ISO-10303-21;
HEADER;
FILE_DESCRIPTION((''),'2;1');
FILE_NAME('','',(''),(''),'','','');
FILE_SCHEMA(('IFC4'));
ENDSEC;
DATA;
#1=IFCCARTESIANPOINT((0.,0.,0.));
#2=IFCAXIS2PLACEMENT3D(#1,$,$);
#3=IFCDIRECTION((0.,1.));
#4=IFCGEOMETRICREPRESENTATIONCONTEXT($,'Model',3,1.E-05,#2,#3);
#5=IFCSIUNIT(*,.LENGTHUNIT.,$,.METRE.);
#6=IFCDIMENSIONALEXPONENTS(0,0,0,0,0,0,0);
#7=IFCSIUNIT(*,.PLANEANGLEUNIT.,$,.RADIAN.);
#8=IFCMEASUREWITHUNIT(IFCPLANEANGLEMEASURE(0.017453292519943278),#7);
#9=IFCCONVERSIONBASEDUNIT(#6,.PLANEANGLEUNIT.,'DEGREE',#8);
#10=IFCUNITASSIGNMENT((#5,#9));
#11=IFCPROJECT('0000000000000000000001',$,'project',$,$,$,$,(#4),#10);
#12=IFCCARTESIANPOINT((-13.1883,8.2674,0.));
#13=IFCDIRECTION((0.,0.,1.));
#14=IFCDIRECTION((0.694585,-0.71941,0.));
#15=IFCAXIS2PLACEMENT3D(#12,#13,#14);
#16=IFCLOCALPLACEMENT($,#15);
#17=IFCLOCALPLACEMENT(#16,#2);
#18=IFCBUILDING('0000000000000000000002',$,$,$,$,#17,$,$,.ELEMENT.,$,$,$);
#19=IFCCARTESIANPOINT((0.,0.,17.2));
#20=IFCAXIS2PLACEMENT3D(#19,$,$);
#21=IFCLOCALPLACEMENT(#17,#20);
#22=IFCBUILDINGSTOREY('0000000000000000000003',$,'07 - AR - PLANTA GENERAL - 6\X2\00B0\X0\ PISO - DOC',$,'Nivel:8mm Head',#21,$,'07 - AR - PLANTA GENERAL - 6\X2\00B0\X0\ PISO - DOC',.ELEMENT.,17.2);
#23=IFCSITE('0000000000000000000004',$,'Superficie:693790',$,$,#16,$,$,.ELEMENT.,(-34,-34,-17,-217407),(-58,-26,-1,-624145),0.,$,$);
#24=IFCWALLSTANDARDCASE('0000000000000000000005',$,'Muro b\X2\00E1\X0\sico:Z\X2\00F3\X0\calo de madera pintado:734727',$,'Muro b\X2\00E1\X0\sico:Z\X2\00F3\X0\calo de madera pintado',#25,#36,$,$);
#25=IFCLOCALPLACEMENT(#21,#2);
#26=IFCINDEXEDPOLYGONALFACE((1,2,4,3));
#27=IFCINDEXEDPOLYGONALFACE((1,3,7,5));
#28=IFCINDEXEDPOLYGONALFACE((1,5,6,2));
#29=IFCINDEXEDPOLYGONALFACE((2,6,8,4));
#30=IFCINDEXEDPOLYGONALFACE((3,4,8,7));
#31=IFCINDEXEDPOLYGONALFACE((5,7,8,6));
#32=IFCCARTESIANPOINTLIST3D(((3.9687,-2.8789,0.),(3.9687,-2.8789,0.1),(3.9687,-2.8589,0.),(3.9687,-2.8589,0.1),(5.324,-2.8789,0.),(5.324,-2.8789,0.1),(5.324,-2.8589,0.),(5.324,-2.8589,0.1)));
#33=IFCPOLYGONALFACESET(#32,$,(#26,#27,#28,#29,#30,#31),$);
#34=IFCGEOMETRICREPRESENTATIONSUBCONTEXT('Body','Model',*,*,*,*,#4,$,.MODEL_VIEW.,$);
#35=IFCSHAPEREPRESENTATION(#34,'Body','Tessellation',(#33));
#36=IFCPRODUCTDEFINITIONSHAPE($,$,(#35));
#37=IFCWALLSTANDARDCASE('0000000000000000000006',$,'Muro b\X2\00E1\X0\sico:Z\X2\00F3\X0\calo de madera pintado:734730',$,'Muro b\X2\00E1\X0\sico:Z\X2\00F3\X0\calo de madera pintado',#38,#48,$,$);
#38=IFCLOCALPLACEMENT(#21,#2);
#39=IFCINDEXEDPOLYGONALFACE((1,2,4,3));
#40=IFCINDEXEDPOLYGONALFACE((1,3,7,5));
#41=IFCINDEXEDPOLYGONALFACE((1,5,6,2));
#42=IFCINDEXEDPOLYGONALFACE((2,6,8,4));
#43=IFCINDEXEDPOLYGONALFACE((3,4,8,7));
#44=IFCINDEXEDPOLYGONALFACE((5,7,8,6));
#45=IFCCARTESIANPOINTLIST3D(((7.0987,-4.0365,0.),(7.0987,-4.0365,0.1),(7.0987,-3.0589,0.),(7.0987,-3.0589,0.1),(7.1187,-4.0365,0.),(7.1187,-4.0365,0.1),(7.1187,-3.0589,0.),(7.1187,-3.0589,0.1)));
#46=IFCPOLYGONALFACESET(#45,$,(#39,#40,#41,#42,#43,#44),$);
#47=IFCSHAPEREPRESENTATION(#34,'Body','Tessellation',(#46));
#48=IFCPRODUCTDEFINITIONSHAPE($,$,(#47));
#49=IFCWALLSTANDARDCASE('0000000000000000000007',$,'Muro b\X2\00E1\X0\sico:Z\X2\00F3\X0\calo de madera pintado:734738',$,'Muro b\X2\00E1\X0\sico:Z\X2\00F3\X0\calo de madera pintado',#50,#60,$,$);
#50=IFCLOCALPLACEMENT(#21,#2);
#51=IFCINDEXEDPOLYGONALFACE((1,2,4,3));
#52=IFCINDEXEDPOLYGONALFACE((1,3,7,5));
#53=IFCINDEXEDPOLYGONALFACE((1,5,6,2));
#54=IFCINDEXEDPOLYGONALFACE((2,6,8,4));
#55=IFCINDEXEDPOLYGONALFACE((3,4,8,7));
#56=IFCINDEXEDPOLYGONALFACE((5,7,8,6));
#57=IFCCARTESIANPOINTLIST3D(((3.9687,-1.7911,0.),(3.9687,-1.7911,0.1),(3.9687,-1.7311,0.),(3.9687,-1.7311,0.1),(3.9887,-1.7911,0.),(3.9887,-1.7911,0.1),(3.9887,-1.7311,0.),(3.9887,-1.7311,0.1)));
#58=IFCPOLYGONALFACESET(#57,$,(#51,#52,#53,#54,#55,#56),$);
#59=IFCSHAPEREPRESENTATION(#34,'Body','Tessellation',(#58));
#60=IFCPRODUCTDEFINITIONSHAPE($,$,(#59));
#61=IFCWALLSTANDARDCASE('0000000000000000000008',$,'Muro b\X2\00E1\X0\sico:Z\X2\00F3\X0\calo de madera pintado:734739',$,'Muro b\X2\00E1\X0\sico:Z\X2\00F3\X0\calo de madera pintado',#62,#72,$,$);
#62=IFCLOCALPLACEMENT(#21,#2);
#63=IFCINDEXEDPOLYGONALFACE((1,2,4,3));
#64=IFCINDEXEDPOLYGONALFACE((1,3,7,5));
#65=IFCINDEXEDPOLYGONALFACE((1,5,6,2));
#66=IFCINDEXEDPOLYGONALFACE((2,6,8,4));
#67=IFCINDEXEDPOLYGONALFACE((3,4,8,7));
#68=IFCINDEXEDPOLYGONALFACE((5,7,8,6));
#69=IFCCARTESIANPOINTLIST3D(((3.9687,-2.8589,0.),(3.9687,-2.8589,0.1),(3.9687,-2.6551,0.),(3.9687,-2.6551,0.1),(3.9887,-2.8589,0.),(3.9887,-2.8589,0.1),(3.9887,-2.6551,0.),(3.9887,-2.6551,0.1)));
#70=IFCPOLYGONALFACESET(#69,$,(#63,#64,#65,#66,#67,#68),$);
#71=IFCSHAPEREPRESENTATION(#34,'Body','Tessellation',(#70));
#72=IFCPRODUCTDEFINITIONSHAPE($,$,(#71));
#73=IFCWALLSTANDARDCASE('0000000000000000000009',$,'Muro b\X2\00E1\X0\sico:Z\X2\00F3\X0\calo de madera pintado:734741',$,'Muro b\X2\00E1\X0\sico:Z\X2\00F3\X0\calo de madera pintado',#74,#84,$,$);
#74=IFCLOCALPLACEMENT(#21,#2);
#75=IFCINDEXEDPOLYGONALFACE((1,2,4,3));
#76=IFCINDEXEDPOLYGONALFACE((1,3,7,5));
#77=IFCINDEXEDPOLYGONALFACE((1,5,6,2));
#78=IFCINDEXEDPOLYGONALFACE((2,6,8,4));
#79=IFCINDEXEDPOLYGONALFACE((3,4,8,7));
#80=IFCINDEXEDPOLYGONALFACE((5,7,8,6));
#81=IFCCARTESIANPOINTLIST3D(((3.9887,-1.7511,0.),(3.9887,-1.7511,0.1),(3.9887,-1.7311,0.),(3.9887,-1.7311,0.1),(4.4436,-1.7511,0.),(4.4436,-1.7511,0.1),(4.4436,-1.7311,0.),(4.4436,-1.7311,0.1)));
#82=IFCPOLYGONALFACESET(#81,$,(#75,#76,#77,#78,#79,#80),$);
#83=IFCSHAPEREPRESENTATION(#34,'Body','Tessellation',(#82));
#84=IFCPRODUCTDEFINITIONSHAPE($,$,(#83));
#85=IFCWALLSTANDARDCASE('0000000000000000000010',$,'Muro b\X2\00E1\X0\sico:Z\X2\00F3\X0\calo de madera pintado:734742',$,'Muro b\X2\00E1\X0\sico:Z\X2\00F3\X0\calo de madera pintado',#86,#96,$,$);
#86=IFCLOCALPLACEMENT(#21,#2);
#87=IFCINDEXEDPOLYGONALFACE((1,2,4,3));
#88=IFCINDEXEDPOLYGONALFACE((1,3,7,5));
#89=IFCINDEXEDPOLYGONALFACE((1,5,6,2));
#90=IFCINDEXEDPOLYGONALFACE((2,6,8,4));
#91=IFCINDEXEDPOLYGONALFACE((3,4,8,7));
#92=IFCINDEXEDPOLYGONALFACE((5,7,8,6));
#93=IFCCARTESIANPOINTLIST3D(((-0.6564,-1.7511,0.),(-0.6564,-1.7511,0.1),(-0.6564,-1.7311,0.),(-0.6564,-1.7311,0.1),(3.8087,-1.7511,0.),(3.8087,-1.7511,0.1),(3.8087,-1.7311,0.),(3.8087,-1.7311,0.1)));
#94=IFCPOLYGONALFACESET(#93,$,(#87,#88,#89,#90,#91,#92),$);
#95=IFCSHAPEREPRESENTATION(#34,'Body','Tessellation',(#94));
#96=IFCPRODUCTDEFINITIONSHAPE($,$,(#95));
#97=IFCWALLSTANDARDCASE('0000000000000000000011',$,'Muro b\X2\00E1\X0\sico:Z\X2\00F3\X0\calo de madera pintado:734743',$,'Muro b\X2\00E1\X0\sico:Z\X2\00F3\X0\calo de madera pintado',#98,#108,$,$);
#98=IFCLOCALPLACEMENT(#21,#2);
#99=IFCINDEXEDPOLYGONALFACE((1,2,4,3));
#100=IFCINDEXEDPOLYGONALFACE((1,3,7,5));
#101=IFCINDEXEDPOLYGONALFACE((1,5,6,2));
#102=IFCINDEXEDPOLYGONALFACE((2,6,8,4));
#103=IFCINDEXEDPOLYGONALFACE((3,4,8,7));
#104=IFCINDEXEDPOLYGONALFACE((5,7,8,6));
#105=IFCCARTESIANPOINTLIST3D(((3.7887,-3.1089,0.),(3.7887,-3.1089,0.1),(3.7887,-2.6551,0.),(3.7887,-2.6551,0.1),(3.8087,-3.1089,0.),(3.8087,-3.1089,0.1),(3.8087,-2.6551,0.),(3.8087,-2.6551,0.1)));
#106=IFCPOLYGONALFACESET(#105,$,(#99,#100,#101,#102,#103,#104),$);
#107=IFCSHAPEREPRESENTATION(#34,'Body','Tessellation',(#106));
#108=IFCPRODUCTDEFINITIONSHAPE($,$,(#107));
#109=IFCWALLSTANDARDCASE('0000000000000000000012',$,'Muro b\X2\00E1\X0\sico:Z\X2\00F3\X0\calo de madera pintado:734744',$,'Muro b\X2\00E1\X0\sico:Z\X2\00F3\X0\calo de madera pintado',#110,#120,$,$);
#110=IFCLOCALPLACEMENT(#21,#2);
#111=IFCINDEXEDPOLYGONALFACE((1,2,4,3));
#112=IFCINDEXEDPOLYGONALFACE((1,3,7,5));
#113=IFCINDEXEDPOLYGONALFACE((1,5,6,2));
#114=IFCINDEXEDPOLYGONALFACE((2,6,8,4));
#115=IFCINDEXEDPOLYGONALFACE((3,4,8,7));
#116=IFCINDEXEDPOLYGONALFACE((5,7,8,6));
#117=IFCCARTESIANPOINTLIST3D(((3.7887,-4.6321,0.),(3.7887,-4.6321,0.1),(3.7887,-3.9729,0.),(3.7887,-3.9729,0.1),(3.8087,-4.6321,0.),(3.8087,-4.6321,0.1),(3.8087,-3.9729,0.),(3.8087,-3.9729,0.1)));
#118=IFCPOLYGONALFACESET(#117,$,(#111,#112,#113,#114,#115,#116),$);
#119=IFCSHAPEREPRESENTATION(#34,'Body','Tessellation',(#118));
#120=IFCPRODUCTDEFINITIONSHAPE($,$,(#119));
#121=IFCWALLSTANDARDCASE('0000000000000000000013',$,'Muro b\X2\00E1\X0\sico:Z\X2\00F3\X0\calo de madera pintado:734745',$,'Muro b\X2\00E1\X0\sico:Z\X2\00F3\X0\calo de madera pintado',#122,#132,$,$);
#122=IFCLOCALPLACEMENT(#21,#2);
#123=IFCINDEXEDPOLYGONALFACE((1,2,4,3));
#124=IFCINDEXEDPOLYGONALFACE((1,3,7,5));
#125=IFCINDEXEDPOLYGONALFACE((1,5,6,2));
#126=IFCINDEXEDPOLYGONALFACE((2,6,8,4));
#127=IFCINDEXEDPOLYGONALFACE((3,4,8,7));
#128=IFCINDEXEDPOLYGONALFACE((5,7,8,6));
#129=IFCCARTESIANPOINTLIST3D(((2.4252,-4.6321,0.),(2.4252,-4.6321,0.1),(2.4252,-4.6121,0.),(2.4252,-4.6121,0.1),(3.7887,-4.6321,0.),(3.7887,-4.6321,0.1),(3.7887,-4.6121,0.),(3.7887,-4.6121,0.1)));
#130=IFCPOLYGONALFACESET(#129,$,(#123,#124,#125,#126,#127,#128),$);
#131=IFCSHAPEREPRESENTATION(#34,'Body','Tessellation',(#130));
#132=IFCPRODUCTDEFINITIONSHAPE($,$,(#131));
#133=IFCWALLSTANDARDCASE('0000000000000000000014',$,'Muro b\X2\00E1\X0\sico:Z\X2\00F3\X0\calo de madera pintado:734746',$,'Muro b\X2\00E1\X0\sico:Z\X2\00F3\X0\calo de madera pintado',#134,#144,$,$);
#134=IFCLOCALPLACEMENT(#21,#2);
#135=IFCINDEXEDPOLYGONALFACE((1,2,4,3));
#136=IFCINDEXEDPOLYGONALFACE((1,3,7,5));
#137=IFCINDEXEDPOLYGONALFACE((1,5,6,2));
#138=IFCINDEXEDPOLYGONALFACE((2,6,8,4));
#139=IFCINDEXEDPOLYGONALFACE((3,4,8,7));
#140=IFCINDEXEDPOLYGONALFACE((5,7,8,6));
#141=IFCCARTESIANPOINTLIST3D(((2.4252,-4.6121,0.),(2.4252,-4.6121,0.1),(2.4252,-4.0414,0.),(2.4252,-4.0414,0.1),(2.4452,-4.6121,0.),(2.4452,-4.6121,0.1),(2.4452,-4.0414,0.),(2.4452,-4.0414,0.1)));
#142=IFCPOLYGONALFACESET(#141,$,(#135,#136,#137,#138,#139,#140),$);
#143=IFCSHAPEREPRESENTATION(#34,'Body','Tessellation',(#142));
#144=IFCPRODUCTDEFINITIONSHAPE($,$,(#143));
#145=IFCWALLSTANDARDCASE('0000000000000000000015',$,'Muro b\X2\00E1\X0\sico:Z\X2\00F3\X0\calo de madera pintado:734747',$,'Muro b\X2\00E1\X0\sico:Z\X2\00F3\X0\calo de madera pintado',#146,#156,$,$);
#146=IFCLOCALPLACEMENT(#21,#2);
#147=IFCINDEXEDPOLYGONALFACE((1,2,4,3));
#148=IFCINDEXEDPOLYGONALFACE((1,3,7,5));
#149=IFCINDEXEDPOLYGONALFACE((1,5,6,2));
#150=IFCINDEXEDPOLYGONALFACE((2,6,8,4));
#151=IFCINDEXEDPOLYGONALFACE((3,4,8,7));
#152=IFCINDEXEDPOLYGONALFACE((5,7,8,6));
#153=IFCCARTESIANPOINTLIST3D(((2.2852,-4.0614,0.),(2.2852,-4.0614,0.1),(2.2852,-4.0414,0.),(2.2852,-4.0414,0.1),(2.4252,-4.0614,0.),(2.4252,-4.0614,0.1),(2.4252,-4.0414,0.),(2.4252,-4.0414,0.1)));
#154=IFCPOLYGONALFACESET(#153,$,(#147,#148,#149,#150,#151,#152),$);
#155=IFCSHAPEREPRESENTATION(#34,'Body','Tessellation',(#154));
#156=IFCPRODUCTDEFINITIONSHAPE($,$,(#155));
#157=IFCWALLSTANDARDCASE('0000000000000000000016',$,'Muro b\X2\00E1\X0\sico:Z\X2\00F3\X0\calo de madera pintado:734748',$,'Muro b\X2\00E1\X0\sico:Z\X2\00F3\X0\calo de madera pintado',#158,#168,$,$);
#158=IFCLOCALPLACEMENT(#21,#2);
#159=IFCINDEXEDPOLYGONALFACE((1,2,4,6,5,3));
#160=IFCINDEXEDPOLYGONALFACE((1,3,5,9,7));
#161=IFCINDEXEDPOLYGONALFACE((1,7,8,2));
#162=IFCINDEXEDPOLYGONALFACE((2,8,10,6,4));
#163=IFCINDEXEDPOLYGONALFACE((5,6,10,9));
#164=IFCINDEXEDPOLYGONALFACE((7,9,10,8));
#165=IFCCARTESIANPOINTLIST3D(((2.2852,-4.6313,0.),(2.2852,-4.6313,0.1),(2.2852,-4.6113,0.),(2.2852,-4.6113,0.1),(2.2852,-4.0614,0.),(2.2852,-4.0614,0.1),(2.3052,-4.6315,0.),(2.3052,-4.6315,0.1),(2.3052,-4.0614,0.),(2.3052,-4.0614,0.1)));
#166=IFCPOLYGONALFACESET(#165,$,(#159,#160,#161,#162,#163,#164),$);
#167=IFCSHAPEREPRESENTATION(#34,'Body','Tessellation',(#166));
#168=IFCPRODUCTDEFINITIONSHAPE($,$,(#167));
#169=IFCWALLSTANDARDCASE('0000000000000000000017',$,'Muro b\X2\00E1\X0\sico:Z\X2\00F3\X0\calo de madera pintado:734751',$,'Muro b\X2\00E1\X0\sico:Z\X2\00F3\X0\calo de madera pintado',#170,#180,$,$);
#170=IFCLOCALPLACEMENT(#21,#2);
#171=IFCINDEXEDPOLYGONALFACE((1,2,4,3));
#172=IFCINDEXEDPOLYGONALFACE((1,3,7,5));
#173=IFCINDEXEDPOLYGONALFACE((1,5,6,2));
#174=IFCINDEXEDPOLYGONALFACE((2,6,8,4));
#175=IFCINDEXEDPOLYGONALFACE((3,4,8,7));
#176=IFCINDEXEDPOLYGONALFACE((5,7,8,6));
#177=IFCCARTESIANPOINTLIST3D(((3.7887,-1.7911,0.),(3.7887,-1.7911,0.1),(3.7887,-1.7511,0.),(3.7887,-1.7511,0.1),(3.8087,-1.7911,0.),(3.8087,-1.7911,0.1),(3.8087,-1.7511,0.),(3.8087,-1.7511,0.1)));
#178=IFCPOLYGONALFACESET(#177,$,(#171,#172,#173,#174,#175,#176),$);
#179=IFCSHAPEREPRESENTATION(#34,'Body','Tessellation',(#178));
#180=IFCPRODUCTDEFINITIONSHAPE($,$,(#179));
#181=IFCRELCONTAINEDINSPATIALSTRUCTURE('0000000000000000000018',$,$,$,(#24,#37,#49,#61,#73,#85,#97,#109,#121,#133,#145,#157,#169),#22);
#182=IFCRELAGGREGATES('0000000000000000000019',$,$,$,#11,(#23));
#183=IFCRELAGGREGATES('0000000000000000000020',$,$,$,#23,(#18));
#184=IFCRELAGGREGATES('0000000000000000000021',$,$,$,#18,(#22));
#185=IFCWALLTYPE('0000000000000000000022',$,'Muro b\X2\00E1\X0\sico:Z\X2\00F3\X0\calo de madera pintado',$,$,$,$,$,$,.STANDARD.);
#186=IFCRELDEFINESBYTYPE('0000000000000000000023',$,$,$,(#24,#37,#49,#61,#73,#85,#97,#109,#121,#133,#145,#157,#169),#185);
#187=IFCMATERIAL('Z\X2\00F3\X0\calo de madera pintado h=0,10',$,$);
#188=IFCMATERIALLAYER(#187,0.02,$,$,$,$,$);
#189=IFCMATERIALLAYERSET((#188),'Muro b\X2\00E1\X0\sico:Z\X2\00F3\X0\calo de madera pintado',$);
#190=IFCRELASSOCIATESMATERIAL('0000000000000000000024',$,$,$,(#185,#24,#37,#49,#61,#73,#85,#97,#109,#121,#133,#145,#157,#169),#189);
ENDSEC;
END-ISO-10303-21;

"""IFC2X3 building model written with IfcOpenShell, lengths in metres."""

from ifc_helpers import new_model, entity, si_unit, converted_unit, direction, frame, frame_2d, origin, place, context, subcontext, project, spatial, polyline, rectangle, outline, extrude, material, layer, layer_set, layer_usage, type_object, element, save


model = new_model("IFC2X3")

# Units and contexts
model_context = context("Model", 3, precision=1e-05, world=origin(), true_north=direction((0.0, 1.0)))
body_context = subcontext(model_context, "Body", "Model", "MODEL_VIEW")
ifc_project = project(units=[si_unit("LENGTHUNIT", "METRE"), converted_unit("PLANEANGLEUNIT", "DEGREE", entity("IfcPlaneAngleMeasure", 0.017453292519943278), si_unit("PLANEANGLEUNIT", "RADIAN"), dimensions=[0, 0, 0, 0, 0, 0, 0])], contexts=[model_context])

# Site, building, storey
site_placement = place(None, frame((-13.1883, 8.2674, 0.0), z_axis=(0.0, 0.0, 1.0), x_axis=(0.694585, -0.71941, 0.0)))
site = spatial("IfcSite", under=ifc_project, at=site_placement, Name="Superficie:693790", CompositionType="ELEMENT", RefLatitude=(-34, -34, -17, -217407), RefLongitude=(-58, -26, -1, -624145), RefElevation=0.0)
building_placement = place(site_placement, origin())
building = spatial("IfcBuilding", under=site, at=building_placement, CompositionType="ELEMENT")
storey_placement = place(building_placement, frame((0.0, 0.0, 17.2)))
storey = spatial("IfcBuildingStorey", under=building, at=storey_placement, Name="07 - AR - PLANTA GENERAL - 6° PISO - DOC", ObjectType="Nivel:8mm Head", LongName="07 - AR - PLANTA GENERAL - 6° PISO - DOC", CompositionType="ELEMENT", Elevation=17.2)

# Walls
ifc_material_1 = material(Name="Zócalo de madera pintado h=0,10")
ifc_layer_1 = layer(ifc_material_1, 0.02)
ifc_layer_set_1 = layer_set([ifc_layer_1], Name="Muro básico:Zócalo de madera pintado")
wall_type_1 = type_object("IfcWallType", Name="Muro básico:Zócalo de madera pintado", PredefinedType="STANDARD", material=ifc_layer_set_1)
ifc_layer_usage_1 = layer_usage(ifc_layer_set_1, "AXIS2", "NEGATIVE", 0.01)
wall_1_placement = place(storey_placement, frame((5.324, -2.8689, 0.0), z_axis=(0.0, 0.0, 1.0), x_axis=(-1.0, 0.0, 0.0)))
element("IfcWallStandardCase", 1, at=wall_1_placement, inside=storey, type_object=wall_type_1, material=ifc_layer_usage_1, Name="Muro básico:Zócalo de madera pintado:734727", ObjectType="Muro básico:Zócalo de madera pintado", context=body_context, shape_type="SweptSolid", body=[
    extrude(rectangle(XDim=1.3553, YDim=0.02, at=frame_2d((0.6776, 0.0), x_axis=(-1.0, 0.0))), origin(), (0.0, 0.0, 1.0), 0.1),
])
ifc_layer_usage_2 = layer_usage(ifc_layer_set_1, "AXIS2", "NEGATIVE", 0.01)
wall_2_placement = place(storey_placement, frame((7.1087, -4.0365, 0.0), z_axis=(0.0, 0.0, 1.0), x_axis=(0.0, 1.0, 0.0)))
element("IfcWallStandardCase", 2, at=wall_2_placement, inside=storey, type_object=wall_type_1, material=ifc_layer_usage_2, Name="Muro básico:Zócalo de madera pintado:734730", ObjectType="Muro básico:Zócalo de madera pintado", context=body_context, shape_type="SweptSolid", body=[
    extrude(rectangle(XDim=0.9776, YDim=0.02, at=frame_2d((0.4888, 0.0), x_axis=(-1.0, 0.0))), origin(), (0.0, 0.0, 1.0), 0.1),
])
ifc_layer_usage_3 = layer_usage(ifc_layer_set_1, "AXIS2", "NEGATIVE", 0.01)
wall_3_placement = place(storey_placement, frame((3.9787, -1.7911, 0.0), z_axis=(0.0, 0.0, 1.0), x_axis=(0.0, 1.0, 0.0)))
element("IfcWallStandardCase", 3, at=wall_3_placement, inside=storey, type_object=wall_type_1, material=ifc_layer_usage_3, Name="Muro básico:Zócalo de madera pintado:734738", ObjectType="Muro básico:Zócalo de madera pintado", context=body_context, shape_type="SweptSolid", body=[
    extrude(rectangle(XDim=0.06, YDim=0.02, at=frame_2d((0.03, 0.0), x_axis=(-1.0, 0.0))), origin(), (0.0, 0.0, 1.0), 0.1),
])
ifc_layer_usage_4 = layer_usage(ifc_layer_set_1, "AXIS2", "NEGATIVE", 0.01)
wall_4_placement = place(storey_placement, frame((3.9787, -2.8589, 0.0), z_axis=(0.0, 0.0, 1.0), x_axis=(0.0, 1.0, 0.0)))
element("IfcWallStandardCase", 4, at=wall_4_placement, inside=storey, type_object=wall_type_1, material=ifc_layer_usage_4, Name="Muro básico:Zócalo de madera pintado:734739", ObjectType="Muro básico:Zócalo de madera pintado", context=body_context, shape_type="SweptSolid", body=[
    extrude(rectangle(XDim=0.2038, YDim=0.02, at=frame_2d((0.1019, 0.0), x_axis=(-1.0, 0.0))), origin(), (0.0, 0.0, 1.0), 0.1),
])
ifc_layer_usage_5 = layer_usage(ifc_layer_set_1, "AXIS2", "NEGATIVE", 0.01)
wall_5_placement = place(storey_placement, frame((3.9887, -1.7411, 0.0)))
element("IfcWallStandardCase", 5, at=wall_5_placement, inside=storey, type_object=wall_type_1, material=ifc_layer_usage_5, Name="Muro básico:Zócalo de madera pintado:734741", ObjectType="Muro básico:Zócalo de madera pintado", context=body_context, shape_type="SweptSolid", body=[
    extrude(rectangle(XDim=0.4549, YDim=0.02, at=frame_2d((0.2275, 0.0), x_axis=(-1.0, 0.0))), origin(), (0.0, 0.0, 1.0), 0.1),
])
ifc_layer_usage_6 = layer_usage(ifc_layer_set_1, "AXIS2", "NEGATIVE", 0.01)
wall_6_placement = place(storey_placement, frame((3.8087, -1.7411, 0.0), z_axis=(0.0, 0.0, 1.0), x_axis=(-1.0, 0.0, 0.0)))
element("IfcWallStandardCase", 6, at=wall_6_placement, inside=storey, type_object=wall_type_1, material=ifc_layer_usage_6, Name="Muro básico:Zócalo de madera pintado:734742", ObjectType="Muro básico:Zócalo de madera pintado", context=body_context, shape_type="SweptSolid", body=[
    extrude(rectangle(XDim=4.4651, YDim=0.02, at=frame_2d((2.2326, 0.0), x_axis=(-1.0, 0.0))), origin(), (0.0, 0.0, 1.0), 0.1),
])
ifc_layer_usage_7 = layer_usage(ifc_layer_set_1, "AXIS2", "NEGATIVE", 0.01)
wall_7_placement = place(storey_placement, frame((3.7987, -3.1089, 0.0), z_axis=(0.0, 0.0, 1.0), x_axis=(0.0, 1.0, 0.0)))
element("IfcWallStandardCase", 7, at=wall_7_placement, inside=storey, type_object=wall_type_1, material=ifc_layer_usage_7, Name="Muro básico:Zócalo de madera pintado:734743", ObjectType="Muro básico:Zócalo de madera pintado", context=body_context, shape_type="SweptSolid", body=[
    extrude(rectangle(XDim=0.4538, YDim=0.02, at=frame_2d((0.2269, 0.0), x_axis=(-1.0, 0.0))), origin(), (0.0, 0.0, 1.0), 0.1),
])
ifc_layer_usage_8 = layer_usage(ifc_layer_set_1, "AXIS2", "NEGATIVE", 0.01)
wall_8_placement = place(storey_placement, frame((3.7987, -4.6321, 0.0), z_axis=(0.0, 0.0, 1.0), x_axis=(0.0, 1.0, 0.0)))
element("IfcWallStandardCase", 8, at=wall_8_placement, inside=storey, type_object=wall_type_1, material=ifc_layer_usage_8, Name="Muro básico:Zócalo de madera pintado:734744", ObjectType="Muro básico:Zócalo de madera pintado", context=body_context, shape_type="SweptSolid", body=[
    extrude(rectangle(XDim=0.6592, YDim=0.02, at=frame_2d((0.3296, 0.0), x_axis=(-1.0, 0.0))), origin(), (0.0, 0.0, 1.0), 0.1),
])
ifc_layer_usage_9 = layer_usage(ifc_layer_set_1, "AXIS2", "NEGATIVE", 0.01)
wall_9_placement = place(storey_placement, frame((2.4252, -4.6221, 0.0)))
element("IfcWallStandardCase", 9, at=wall_9_placement, inside=storey, type_object=wall_type_1, material=ifc_layer_usage_9, Name="Muro básico:Zócalo de madera pintado:734745", ObjectType="Muro básico:Zócalo de madera pintado", context=body_context, shape_type="SweptSolid", body=[
    extrude(rectangle(XDim=1.3635, YDim=0.02, at=frame_2d((0.6818, 0.0), x_axis=(-1.0, 0.0))), origin(), (0.0, 0.0, 1.0), 0.1),
])
ifc_layer_usage_10 = layer_usage(ifc_layer_set_1, "AXIS2", "NEGATIVE", 0.01)
wall_10_placement = place(storey_placement, frame((2.4352, -4.0414, 0.0), z_axis=(0.0, 0.0, 1.0), x_axis=(0.0, -1.0, 0.0)))
element("IfcWallStandardCase", 10, at=wall_10_placement, inside=storey, type_object=wall_type_1, material=ifc_layer_usage_10, Name="Muro básico:Zócalo de madera pintado:734746", ObjectType="Muro básico:Zócalo de madera pintado", context=body_context, shape_type="SweptSolid", body=[
    extrude(rectangle(XDim=0.5707, YDim=0.02, at=frame_2d((0.2854, 0.0), x_axis=(-1.0, 0.0))), origin(), (0.0, 0.0, 1.0), 0.1),
])
ifc_layer_usage_11 = layer_usage(ifc_layer_set_1, "AXIS2", "NEGATIVE", 0.01)
wall_11_placement = place(storey_placement, frame((2.2852, -4.0514, 0.0)))
element("IfcWallStandardCase", 11, at=wall_11_placement, inside=storey, type_object=wall_type_1, material=ifc_layer_usage_11, Name="Muro básico:Zócalo de madera pintado:734747", ObjectType="Muro básico:Zócalo de madera pintado", context=body_context, shape_type="SweptSolid", body=[
    extrude(rectangle(XDim=0.14, YDim=0.02, at=frame_2d((0.07, 0.0), x_axis=(-1.0, 0.0))), origin(), (0.0, 0.0, 1.0), 0.1),
])
ifc_layer_usage_12 = layer_usage(ifc_layer_set_1, "AXIS2", "NEGATIVE", 0.01)
wall_12_placement = place(storey_placement, frame((2.2952, -4.6315, 0.0), z_axis=(0.0, 0.0, 1.0), x_axis=(0.0, 1.0, 0.0)))
element("IfcWallStandardCase", 12, at=wall_12_placement, inside=storey, type_object=wall_type_1, material=ifc_layer_usage_12, Name="Muro básico:Zócalo de madera pintado:734748", ObjectType="Muro básico:Zócalo de madera pintado", context=body_context, shape_type="SweptSolid", body=[
    extrude(outline(polyline([(0.5701, -0.01), (0.5701, 0.01), (0.0201, 0.01), (0.0001, 0.01), (0.0, -0.01), (0.5701, -0.01)])), origin(), (0.0, 0.0, 1.0), 0.1),
])
ifc_layer_usage_13 = layer_usage(ifc_layer_set_1, "AXIS2", "NEGATIVE", 0.01)
wall_13_placement = place(storey_placement, frame((3.7987, -1.7911, 0.0), z_axis=(0.0, 0.0, 1.0), x_axis=(0.0, 1.0, 0.0)))
element("IfcWallStandardCase", 13, at=wall_13_placement, inside=storey, type_object=wall_type_1, material=ifc_layer_usage_13, Name="Muro básico:Zócalo de madera pintado:734751", ObjectType="Muro básico:Zócalo de madera pintado", context=body_context, shape_type="SweptSolid", body=[
    extrude(rectangle(XDim=0.04, YDim=0.02, at=frame_2d((0.02, 0.0), x_axis=(-1.0, 0.0))), origin(), (0.0, 0.0, 1.0), 0.1),
])

save(model, "model.ifc")
